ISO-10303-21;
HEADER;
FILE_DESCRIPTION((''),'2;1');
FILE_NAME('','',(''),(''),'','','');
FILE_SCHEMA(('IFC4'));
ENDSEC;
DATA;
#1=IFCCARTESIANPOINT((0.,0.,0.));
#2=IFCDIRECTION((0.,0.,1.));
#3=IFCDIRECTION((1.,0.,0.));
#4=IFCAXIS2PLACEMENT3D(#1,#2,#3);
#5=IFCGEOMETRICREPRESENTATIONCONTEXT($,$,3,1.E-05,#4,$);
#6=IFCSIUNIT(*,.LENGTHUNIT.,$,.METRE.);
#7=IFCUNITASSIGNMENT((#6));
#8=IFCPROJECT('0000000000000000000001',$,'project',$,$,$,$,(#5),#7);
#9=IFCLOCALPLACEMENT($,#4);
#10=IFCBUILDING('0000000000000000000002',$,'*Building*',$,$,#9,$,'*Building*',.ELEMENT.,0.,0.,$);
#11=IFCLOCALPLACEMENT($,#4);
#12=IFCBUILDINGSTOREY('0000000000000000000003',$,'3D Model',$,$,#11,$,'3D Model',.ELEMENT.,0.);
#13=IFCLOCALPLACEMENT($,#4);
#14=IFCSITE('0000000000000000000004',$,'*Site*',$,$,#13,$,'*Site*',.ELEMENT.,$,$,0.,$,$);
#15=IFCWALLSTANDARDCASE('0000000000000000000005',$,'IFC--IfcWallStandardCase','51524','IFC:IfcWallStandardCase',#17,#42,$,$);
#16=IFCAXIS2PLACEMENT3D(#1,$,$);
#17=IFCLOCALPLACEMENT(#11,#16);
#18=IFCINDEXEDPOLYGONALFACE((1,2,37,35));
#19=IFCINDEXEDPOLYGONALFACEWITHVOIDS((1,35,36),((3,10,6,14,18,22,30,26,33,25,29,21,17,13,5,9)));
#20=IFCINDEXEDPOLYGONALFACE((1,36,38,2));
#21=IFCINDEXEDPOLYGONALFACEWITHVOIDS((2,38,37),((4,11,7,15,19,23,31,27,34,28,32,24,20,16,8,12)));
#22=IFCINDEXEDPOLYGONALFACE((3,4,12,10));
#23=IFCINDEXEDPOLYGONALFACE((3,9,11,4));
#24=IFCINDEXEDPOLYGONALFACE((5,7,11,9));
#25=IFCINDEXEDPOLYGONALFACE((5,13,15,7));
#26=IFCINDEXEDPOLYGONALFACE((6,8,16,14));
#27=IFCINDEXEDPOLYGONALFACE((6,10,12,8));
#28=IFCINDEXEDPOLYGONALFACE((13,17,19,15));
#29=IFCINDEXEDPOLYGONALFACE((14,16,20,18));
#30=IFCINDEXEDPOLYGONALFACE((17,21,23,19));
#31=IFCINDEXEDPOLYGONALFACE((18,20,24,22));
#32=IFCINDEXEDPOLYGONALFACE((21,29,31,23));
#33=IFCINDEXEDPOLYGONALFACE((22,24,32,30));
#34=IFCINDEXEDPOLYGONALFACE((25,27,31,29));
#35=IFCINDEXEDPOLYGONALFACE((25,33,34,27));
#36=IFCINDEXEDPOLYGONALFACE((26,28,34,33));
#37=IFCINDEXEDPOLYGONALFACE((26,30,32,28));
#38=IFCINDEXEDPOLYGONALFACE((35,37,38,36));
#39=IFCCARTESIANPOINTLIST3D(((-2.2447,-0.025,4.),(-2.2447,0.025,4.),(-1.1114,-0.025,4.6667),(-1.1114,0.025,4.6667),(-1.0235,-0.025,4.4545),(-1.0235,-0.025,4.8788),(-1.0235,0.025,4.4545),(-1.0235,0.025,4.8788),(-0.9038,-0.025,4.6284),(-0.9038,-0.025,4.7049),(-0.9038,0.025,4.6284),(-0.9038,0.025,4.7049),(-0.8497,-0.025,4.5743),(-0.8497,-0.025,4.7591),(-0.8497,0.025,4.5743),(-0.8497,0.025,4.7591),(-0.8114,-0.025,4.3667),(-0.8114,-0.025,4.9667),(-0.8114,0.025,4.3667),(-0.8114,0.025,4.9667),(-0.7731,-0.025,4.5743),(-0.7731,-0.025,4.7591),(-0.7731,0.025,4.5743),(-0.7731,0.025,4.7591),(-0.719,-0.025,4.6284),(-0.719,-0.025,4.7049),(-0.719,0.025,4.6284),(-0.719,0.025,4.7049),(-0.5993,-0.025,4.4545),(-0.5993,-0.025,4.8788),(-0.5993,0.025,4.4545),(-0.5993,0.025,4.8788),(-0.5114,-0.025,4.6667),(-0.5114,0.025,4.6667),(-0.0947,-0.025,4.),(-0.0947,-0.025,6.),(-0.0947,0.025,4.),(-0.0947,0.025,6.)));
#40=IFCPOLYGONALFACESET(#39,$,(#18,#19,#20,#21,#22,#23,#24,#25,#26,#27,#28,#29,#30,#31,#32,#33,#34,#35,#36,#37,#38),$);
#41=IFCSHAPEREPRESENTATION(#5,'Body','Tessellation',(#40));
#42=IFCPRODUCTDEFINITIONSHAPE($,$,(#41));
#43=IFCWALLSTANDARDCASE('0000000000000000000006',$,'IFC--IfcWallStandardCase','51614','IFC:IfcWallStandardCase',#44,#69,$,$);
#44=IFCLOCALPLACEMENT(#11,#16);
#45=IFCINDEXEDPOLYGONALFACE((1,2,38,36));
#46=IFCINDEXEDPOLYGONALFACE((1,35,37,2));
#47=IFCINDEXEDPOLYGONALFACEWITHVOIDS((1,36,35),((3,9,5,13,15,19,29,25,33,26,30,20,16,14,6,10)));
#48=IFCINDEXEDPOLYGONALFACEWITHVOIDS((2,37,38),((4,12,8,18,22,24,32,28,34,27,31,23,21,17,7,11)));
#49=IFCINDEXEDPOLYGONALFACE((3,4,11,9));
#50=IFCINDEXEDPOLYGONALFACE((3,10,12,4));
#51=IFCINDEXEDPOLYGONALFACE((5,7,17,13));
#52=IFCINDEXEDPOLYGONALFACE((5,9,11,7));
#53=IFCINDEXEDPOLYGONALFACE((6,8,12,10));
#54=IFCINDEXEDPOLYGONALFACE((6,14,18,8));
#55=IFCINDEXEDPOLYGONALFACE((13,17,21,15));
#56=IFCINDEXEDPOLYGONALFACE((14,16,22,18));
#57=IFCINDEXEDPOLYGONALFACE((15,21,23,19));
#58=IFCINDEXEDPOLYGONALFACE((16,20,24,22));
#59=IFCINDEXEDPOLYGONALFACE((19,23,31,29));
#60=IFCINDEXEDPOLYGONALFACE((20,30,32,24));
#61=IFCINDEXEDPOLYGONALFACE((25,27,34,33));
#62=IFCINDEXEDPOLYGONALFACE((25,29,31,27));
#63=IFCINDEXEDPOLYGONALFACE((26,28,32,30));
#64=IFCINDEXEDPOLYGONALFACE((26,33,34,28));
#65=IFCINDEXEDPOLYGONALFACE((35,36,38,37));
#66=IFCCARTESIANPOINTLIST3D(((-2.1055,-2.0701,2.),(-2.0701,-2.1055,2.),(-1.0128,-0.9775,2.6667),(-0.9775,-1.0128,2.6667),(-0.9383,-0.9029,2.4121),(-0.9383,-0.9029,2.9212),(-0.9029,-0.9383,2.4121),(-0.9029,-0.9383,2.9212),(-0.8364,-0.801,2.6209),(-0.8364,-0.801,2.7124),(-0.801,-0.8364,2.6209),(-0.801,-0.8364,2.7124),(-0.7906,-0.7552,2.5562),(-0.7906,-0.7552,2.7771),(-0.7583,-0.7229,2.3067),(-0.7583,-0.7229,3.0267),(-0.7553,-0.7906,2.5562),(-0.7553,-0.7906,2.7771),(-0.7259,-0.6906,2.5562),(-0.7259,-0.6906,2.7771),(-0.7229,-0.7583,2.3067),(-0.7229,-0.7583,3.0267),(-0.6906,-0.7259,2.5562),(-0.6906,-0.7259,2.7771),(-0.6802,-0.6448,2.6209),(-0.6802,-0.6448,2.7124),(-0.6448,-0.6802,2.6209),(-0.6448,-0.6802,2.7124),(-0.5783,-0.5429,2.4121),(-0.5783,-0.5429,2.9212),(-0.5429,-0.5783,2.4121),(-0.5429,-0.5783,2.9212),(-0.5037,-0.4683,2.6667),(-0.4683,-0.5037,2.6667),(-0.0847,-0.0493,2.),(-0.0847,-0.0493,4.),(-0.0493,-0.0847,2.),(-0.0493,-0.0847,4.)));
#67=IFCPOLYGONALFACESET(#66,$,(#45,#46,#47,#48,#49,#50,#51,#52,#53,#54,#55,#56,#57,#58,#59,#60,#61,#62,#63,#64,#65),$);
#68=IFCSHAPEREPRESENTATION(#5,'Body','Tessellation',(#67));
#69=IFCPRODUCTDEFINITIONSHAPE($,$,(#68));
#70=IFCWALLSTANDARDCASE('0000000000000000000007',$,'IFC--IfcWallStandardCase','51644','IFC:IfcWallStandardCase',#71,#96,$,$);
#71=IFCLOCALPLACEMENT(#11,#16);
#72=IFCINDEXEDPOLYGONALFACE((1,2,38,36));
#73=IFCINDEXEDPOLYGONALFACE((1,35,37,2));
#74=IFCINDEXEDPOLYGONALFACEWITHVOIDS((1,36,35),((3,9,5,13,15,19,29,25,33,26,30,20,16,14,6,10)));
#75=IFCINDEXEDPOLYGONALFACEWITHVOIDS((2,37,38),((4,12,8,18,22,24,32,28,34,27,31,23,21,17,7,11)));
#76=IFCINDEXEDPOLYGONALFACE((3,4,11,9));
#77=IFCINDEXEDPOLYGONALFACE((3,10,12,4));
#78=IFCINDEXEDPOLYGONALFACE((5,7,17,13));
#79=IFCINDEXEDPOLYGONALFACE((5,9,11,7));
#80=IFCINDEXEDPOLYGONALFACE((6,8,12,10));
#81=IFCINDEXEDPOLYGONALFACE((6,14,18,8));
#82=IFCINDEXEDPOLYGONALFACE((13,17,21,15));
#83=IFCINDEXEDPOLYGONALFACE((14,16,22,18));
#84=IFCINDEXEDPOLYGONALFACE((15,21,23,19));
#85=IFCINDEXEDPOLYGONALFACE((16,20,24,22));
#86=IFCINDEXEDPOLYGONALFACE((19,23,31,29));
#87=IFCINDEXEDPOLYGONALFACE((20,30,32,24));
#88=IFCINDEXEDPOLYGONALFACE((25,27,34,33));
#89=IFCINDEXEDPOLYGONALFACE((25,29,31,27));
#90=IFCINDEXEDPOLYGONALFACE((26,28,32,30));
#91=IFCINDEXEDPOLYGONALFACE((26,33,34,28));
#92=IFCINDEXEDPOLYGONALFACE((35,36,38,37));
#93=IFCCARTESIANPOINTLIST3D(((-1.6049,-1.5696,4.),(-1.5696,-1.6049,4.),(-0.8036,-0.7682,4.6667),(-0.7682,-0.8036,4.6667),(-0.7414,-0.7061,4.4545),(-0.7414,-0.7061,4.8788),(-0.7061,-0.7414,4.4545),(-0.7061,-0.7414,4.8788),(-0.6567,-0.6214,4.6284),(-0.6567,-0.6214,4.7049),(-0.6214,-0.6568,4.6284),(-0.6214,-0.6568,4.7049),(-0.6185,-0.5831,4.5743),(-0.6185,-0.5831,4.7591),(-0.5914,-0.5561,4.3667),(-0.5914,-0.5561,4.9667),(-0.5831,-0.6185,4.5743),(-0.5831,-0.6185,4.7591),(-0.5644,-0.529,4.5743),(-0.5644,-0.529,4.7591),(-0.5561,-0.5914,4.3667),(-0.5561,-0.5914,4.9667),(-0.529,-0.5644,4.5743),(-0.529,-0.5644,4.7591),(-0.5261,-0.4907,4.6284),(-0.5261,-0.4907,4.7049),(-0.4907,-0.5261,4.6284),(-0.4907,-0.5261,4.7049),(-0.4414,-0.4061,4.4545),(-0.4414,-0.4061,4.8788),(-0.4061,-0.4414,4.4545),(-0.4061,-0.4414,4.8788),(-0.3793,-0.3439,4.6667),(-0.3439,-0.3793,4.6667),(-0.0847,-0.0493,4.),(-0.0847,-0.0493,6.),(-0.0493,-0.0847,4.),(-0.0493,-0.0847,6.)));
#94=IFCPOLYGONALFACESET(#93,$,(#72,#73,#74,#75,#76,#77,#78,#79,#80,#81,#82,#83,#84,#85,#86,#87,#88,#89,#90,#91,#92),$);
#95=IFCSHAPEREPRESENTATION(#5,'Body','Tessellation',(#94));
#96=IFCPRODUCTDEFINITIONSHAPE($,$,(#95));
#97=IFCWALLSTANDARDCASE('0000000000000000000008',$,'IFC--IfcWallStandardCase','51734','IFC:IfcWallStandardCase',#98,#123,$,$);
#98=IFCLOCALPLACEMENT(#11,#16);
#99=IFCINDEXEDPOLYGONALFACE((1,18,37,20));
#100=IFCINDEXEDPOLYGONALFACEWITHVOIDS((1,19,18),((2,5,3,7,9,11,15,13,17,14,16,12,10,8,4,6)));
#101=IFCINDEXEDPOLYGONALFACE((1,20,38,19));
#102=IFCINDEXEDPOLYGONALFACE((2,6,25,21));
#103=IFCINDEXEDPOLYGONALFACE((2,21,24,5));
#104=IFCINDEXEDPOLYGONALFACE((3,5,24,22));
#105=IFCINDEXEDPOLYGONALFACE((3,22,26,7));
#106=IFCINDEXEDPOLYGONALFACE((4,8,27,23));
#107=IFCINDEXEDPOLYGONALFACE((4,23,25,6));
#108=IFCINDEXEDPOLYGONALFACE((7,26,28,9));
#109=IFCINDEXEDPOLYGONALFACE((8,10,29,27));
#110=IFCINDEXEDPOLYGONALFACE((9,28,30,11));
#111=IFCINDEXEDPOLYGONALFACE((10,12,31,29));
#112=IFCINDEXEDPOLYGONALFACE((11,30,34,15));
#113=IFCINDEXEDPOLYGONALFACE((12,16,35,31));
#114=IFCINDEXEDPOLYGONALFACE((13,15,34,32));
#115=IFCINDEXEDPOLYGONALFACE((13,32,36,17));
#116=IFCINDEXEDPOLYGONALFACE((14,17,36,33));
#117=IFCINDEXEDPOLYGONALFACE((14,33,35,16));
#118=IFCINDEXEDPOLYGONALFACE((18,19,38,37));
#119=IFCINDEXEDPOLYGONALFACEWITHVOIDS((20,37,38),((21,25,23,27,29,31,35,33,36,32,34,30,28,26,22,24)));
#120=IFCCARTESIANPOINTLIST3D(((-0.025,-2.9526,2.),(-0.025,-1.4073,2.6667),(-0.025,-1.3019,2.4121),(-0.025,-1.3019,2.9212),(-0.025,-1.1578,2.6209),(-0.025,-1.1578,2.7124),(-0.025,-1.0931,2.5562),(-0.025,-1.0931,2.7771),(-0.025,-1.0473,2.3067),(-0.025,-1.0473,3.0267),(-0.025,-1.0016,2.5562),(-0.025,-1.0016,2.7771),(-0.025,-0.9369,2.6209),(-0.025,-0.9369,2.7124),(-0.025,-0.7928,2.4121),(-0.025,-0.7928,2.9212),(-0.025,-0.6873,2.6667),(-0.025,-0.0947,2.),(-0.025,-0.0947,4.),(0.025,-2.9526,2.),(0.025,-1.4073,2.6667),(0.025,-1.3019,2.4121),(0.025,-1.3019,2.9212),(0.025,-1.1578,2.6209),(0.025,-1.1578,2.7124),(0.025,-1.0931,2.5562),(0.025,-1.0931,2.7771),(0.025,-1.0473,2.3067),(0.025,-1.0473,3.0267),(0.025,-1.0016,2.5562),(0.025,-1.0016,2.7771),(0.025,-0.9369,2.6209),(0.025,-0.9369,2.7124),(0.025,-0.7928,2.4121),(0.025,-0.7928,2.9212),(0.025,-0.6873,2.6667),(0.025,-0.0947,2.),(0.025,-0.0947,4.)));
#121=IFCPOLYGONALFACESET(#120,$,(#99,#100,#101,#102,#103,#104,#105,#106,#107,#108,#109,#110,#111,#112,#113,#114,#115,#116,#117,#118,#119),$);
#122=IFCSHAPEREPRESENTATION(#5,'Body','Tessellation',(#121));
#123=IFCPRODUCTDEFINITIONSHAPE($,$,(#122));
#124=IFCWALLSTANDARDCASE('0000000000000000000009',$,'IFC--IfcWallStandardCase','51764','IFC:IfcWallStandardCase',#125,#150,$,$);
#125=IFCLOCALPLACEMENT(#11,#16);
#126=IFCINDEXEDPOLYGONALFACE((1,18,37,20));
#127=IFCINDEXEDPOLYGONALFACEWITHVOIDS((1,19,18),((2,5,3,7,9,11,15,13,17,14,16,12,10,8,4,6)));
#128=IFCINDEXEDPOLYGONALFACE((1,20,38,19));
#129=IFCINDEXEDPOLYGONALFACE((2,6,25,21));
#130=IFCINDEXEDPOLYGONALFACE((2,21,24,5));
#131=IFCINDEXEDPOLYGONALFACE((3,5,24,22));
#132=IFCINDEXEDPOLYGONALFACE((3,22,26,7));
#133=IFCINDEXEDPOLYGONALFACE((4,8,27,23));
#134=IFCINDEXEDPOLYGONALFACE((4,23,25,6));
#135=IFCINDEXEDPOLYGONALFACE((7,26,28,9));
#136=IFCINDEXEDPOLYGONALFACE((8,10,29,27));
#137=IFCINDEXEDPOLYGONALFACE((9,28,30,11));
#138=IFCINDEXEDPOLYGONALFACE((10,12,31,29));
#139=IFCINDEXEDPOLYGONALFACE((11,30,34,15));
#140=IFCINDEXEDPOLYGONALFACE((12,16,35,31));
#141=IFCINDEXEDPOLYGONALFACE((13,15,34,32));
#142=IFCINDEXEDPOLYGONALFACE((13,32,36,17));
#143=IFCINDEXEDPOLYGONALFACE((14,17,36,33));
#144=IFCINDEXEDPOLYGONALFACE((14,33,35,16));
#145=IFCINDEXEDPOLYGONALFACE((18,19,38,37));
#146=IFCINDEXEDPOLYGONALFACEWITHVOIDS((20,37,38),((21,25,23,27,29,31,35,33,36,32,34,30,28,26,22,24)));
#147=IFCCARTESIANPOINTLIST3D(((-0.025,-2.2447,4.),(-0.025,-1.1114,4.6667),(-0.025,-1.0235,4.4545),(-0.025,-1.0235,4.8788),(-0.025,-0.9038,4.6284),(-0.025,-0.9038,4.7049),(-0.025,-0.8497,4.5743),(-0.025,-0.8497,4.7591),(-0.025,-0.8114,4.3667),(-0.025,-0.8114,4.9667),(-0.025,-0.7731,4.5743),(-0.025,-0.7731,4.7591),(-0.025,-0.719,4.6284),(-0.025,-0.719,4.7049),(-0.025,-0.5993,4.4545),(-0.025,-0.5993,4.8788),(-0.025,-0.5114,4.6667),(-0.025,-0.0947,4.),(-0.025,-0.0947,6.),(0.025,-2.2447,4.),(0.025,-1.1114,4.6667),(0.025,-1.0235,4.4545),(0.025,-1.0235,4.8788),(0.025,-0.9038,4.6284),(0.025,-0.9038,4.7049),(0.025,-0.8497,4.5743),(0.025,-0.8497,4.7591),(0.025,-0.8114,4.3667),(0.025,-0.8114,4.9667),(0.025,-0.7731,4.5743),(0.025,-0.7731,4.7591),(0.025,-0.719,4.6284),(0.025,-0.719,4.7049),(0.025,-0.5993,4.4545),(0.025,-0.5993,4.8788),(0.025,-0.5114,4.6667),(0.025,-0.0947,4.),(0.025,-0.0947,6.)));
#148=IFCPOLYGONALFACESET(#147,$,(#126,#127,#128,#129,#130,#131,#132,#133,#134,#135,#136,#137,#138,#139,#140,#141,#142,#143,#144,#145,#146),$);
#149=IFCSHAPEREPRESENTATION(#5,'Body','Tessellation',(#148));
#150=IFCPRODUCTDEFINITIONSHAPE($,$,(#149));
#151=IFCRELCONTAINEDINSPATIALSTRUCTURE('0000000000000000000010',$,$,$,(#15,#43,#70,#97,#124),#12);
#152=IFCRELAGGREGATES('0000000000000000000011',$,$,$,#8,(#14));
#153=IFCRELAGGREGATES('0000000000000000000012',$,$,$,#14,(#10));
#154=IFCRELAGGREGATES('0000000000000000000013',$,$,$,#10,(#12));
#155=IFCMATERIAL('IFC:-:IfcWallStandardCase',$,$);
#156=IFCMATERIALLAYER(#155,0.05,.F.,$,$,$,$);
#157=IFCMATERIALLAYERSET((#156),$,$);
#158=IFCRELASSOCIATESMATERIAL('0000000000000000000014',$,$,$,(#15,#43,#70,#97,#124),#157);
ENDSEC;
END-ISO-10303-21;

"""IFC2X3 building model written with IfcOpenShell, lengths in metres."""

from ifc_helpers import new_model, si_unit, frame, frame_2d, origin_with_axes, place, context, project, spatial, polyline, rectangle, outline, extrude, clip, halfspace, material, layer, layer_set, layer_usage, element, save


model = new_model("IFC2X3")

# Units and contexts
context_of_model = context(None, 3, precision=1e-05, world=origin_with_axes())
ifc_project = project(units=[si_unit("LENGTHUNIT", "METRE")], contexts=[context_of_model])

# Site, building, storey
site_placement = place(None, origin_with_axes())
site = spatial("IfcSite", under=ifc_project, at=site_placement, Name="*Site*", LongName="*Site*", CompositionType="ELEMENT", RefElevation=0.0)
building_placement = place(None, origin_with_axes())
building = spatial("IfcBuilding", under=site, at=building_placement, Name="*Building*", LongName="*Building*", CompositionType="ELEMENT", ElevationOfRefHeight=0.0, ElevationOfTerrain=0.0)
storey_placement = place(None, origin_with_axes())
storey = spatial("IfcBuildingStorey", under=building, at=storey_placement, Name="3D Model", LongName="3D Model", CompositionType="ELEMENT", Elevation=0.0)

# Walls, openings
ifc_material = material(Name="IFC:-:IfcWallStandardCase")
ifc_layer = layer(ifc_material, 0.05, ventilated=False)
ifc_layer_set = layer_set([ifc_layer])
ifc_layer_usage = layer_usage(ifc_layer_set, "AXIS2", "POSITIVE", 0.0)
wall_1_placement = place(None, frame((-0.0947, 0.0, 4.0), z_axis=(0.0, 0.0, 1.0), x_axis=(-1.0, -0.000003, 0.0)))
wall_1 = element("IfcWallStandardCase", 1, at=wall_1_placement, inside=storey, material=ifc_layer_usage, Name="IFC--IfcWallStandardCase", Description="51524", ObjectType="IFC:IfcWallStandardCase", context=context_of_model, shape_type="Clipping", body=[
    clip(extrude(rectangle(XDim=2.15, YDim=0.05, at=frame_2d((1.075, 0.0), x_axis=(1.0, 0.0))), origin_with_axes(), (0.0, 0.0, 1.0), 2.0), halfspace(frame((0.9974, 0.0, 1.0722), z_axis=(-0.681104, 0.000002, -0.732187), x_axis=(-0.732187, 0.0, 0.681104)), True)),
])
opening_1_placement = place(wall_1_placement, frame((0.4167, -0.025, 0.3667), z_axis=(0.0, 0.0, 1.0), x_axis=(1.0, 0.0, 0.0)))
element("IfcOpeningElement", 2, at=opening_1_placement, cuts=wall_1, context=context_of_model, shape_type="SweptSolid", body=[
    extrude(outline(polyline([(-0.3924, 0.2617), (-0.5121, 0.0879), (-0.3383, 0.2076), (-0.3, 0.0), (-0.2617, 0.2076), (-0.0879, 0.0879), (-0.2076, 0.2617), (0.0, 0.3), (-0.2076, 0.3383), (-0.0879, 0.5121), (-0.2617, 0.3924), (-0.3, 0.6), (-0.3383, 0.3924), (-0.5121, 0.5121), (-0.3924, 0.3383), (-0.6, 0.3), (-0.3924, 0.2617)])), frame((0.0, 0.0, 0.0), z_axis=(0.0, 1.0, 0.0), x_axis=(-1.0, 0.0, 0.0)), (0.0, 0.0, 1.0), 0.075),
])
wall_2_placement = place(None, frame((-0.067, -0.067, 2.0), z_axis=(0.0, 0.0, 1.0), x_axis=(-0.707107, -0.707107, 0.0)))
wall_2 = element("IfcWallStandardCase", 3, at=wall_2_placement, inside=storey, material=ifc_layer_usage, Name="IFC--IfcWallStandardCase", Description="51614", ObjectType="IFC:IfcWallStandardCase", context=context_of_model, shape_type="Clipping", body=[
    clip(extrude(rectangle(XDim=2.8578, YDim=0.05, at=frame_2d((1.4289, 0.0), x_axis=(1.0, 0.0))), origin_with_axes(), (0.0, 0.0, 1.0), 2.0), halfspace(frame((0.9395, 0.0, 1.3425), z_axis=(-0.573369, 0.0, -0.819297), x_axis=(-0.819297, 0.0, 0.573369)), True)),
])
opening_2_placement = place(wall_2_placement, frame((0.5926, -0.025, 0.3067), z_axis=(0.0, 0.0, 1.0), x_axis=(1.0, 0.0, 0.0)))
element("IfcOpeningElement", 4, at=opening_2_placement, cuts=wall_2, context=context_of_model, shape_type="SweptSolid", body=[
    extrude(outline(polyline([(-0.4704, 0.3143), (-0.6146, 0.1054), (-0.4057, 0.2496), (-0.36, 0.0), (-0.3143, 0.2496), (-0.1054, 0.1054), (-0.2496, 0.3143), (0.0, 0.36), (-0.2496, 0.4057), (-0.1054, 0.6146), (-0.3143, 0.4704), (-0.36, 0.72), (-0.4057, 0.4704), (-0.6146, 0.6146), (-0.4704, 0.4057), (-0.72, 0.36), (-0.4704, 0.3143)])), frame((0.0, 0.0, 0.0), z_axis=(-0.000003, 1.0, 0.0), x_axis=(-1.0, -0.000003, 0.0)), (0.0, 0.0, 1.0), 0.075),
])
wall_3_placement = place(None, frame((-0.067, -0.067, 4.0), z_axis=(0.0, 0.0, 1.0), x_axis=(-0.707105, -0.707109, 0.0)))
wall_3 = element("IfcWallStandardCase", 5, at=wall_3_placement, inside=storey, material=ifc_layer_usage, Name="IFC--IfcWallStandardCase", Description="51644", ObjectType="IFC:IfcWallStandardCase", context=context_of_model, shape_type="Clipping", body=[
    clip(extrude(rectangle(XDim=2.15, YDim=0.05, at=frame_2d((1.075, 0.0), x_axis=(1.0, 0.0))), origin_with_axes(), (0.0, 0.0, 1.0), 2.0), halfspace(frame((0.9974, 0.0, 1.0722), z_axis=(-0.681104, 0.000002, -0.732187), x_axis=(-0.732187, 0.0, 0.681104)), True)),
])
opening_3_placement = place(wall_3_placement, frame((0.4167, -0.025, 0.3667), z_axis=(0.0, 0.0, 1.0), x_axis=(1.0, 0.0, 0.0)))
element("IfcOpeningElement", 6, at=opening_3_placement, cuts=wall_3, context=context_of_model, shape_type="SweptSolid", body=[
    extrude(outline(polyline([(-0.3924, 0.2617), (-0.5121, 0.0879), (-0.3383, 0.2076), (-0.3, 0.0), (-0.2617, 0.2076), (-0.0879, 0.0879), (-0.2076, 0.2617), (0.0, 0.3), (-0.2076, 0.3383), (-0.0879, 0.5121), (-0.2617, 0.3924), (-0.3, 0.6), (-0.3383, 0.3924), (-0.5121, 0.5121), (-0.3924, 0.3383), (-0.6, 0.3), (-0.3924, 0.2617)])), frame((0.0, 0.0, 0.0), z_axis=(0.0, 1.0, 0.0), x_axis=(-1.0, 0.0, 0.0)), (0.0, 0.0, 1.0), 0.075),
])
wall_4_placement = place(None, frame((0.0, -0.0947, 2.0), z_axis=(0.0, 0.0, 1.0), x_axis=(0.0, -1.0, 0.0)))
wall_4 = element("IfcWallStandardCase", 7, at=wall_4_placement, inside=storey, material=ifc_layer_usage, Name="IFC--IfcWallStandardCase", Description="51734", ObjectType="IFC:IfcWallStandardCase", context=context_of_model, shape_type="Clipping", body=[
    clip(extrude(rectangle(XDim=2.8578, YDim=0.05, at=frame_2d((1.4289, 0.0), x_axis=(1.0, 0.0))), origin_with_axes(), (0.0, 0.0, 1.0), 2.0), halfspace(frame((0.9395, 0.0, 1.3425), z_axis=(-0.573369, 0.0, -0.819297), x_axis=(-0.819297, 0.0, 0.573369)), True)),
])
opening_4_placement = place(wall_4_placement, frame((0.5926, -0.025, 0.3067), z_axis=(0.0, 0.0, 1.0), x_axis=(1.0, 0.0, 0.0)))
element("IfcOpeningElement", 8, at=opening_4_placement, cuts=wall_4, context=context_of_model, shape_type="SweptSolid", body=[
    extrude(outline(polyline([(-0.4704, 0.3143), (-0.6146, 0.1054), (-0.4057, 0.2496), (-0.36, 0.0), (-0.3143, 0.2496), (-0.1054, 0.1054), (-0.2496, 0.3143), (0.0, 0.36), (-0.2496, 0.4057), (-0.1054, 0.6146), (-0.3143, 0.4704), (-0.36, 0.72), (-0.4057, 0.4704), (-0.6146, 0.6146), (-0.4704, 0.4057), (-0.72, 0.36), (-0.4704, 0.3143)])), frame((0.0, 0.0, 0.0), z_axis=(-0.000003, 1.0, 0.0), x_axis=(-1.0, -0.000003, 0.0)), (0.0, 0.0, 1.0), 0.075),
])
wall_5_placement = place(None, frame((0.0, -0.0947, 4.0), z_axis=(0.0, 0.0, 1.0), x_axis=(0.000003, -1.0, 0.0)))
wall_5 = element("IfcWallStandardCase", 9, at=wall_5_placement, inside=storey, material=ifc_layer_usage, Name="IFC--IfcWallStandardCase", Description="51764", ObjectType="IFC:IfcWallStandardCase", context=context_of_model, shape_type="Clipping", body=[
    clip(extrude(rectangle(XDim=2.15, YDim=0.05, at=frame_2d((1.075, 0.0), x_axis=(1.0, 0.0))), origin_with_axes(), (0.0, 0.0, 1.0), 2.0), halfspace(frame((0.9974, 0.0, 1.0722), z_axis=(-0.681104, 0.000002, -0.732187), x_axis=(-0.732187, 0.0, 0.681104)), True)),
])
opening_5_placement = place(wall_5_placement, frame((0.4167, -0.025, 0.3667), z_axis=(0.0, 0.0, 1.0), x_axis=(1.0, 0.0, 0.0)))
element("IfcOpeningElement", 10, at=opening_5_placement, cuts=wall_5, context=context_of_model, shape_type="SweptSolid", body=[
    extrude(outline(polyline([(-0.3924, 0.2617), (-0.5121, 0.0879), (-0.3383, 0.2076), (-0.3, 0.0), (-0.2617, 0.2076), (-0.0879, 0.0879), (-0.2076, 0.2617), (0.0, 0.3), (-0.2076, 0.3383), (-0.0879, 0.5121), (-0.2617, 0.3924), (-0.3, 0.6), (-0.3383, 0.3924), (-0.5121, 0.5121), (-0.3924, 0.3383), (-0.6, 0.3), (-0.3924, 0.2617)])), frame((0.0, 0.0, 0.0), z_axis=(0.0, 1.0, 0.0), x_axis=(-1.0, 0.0, 0.0)), (0.0, 0.0, 1.0), 0.075),
])

save(model, "model.ifc")
